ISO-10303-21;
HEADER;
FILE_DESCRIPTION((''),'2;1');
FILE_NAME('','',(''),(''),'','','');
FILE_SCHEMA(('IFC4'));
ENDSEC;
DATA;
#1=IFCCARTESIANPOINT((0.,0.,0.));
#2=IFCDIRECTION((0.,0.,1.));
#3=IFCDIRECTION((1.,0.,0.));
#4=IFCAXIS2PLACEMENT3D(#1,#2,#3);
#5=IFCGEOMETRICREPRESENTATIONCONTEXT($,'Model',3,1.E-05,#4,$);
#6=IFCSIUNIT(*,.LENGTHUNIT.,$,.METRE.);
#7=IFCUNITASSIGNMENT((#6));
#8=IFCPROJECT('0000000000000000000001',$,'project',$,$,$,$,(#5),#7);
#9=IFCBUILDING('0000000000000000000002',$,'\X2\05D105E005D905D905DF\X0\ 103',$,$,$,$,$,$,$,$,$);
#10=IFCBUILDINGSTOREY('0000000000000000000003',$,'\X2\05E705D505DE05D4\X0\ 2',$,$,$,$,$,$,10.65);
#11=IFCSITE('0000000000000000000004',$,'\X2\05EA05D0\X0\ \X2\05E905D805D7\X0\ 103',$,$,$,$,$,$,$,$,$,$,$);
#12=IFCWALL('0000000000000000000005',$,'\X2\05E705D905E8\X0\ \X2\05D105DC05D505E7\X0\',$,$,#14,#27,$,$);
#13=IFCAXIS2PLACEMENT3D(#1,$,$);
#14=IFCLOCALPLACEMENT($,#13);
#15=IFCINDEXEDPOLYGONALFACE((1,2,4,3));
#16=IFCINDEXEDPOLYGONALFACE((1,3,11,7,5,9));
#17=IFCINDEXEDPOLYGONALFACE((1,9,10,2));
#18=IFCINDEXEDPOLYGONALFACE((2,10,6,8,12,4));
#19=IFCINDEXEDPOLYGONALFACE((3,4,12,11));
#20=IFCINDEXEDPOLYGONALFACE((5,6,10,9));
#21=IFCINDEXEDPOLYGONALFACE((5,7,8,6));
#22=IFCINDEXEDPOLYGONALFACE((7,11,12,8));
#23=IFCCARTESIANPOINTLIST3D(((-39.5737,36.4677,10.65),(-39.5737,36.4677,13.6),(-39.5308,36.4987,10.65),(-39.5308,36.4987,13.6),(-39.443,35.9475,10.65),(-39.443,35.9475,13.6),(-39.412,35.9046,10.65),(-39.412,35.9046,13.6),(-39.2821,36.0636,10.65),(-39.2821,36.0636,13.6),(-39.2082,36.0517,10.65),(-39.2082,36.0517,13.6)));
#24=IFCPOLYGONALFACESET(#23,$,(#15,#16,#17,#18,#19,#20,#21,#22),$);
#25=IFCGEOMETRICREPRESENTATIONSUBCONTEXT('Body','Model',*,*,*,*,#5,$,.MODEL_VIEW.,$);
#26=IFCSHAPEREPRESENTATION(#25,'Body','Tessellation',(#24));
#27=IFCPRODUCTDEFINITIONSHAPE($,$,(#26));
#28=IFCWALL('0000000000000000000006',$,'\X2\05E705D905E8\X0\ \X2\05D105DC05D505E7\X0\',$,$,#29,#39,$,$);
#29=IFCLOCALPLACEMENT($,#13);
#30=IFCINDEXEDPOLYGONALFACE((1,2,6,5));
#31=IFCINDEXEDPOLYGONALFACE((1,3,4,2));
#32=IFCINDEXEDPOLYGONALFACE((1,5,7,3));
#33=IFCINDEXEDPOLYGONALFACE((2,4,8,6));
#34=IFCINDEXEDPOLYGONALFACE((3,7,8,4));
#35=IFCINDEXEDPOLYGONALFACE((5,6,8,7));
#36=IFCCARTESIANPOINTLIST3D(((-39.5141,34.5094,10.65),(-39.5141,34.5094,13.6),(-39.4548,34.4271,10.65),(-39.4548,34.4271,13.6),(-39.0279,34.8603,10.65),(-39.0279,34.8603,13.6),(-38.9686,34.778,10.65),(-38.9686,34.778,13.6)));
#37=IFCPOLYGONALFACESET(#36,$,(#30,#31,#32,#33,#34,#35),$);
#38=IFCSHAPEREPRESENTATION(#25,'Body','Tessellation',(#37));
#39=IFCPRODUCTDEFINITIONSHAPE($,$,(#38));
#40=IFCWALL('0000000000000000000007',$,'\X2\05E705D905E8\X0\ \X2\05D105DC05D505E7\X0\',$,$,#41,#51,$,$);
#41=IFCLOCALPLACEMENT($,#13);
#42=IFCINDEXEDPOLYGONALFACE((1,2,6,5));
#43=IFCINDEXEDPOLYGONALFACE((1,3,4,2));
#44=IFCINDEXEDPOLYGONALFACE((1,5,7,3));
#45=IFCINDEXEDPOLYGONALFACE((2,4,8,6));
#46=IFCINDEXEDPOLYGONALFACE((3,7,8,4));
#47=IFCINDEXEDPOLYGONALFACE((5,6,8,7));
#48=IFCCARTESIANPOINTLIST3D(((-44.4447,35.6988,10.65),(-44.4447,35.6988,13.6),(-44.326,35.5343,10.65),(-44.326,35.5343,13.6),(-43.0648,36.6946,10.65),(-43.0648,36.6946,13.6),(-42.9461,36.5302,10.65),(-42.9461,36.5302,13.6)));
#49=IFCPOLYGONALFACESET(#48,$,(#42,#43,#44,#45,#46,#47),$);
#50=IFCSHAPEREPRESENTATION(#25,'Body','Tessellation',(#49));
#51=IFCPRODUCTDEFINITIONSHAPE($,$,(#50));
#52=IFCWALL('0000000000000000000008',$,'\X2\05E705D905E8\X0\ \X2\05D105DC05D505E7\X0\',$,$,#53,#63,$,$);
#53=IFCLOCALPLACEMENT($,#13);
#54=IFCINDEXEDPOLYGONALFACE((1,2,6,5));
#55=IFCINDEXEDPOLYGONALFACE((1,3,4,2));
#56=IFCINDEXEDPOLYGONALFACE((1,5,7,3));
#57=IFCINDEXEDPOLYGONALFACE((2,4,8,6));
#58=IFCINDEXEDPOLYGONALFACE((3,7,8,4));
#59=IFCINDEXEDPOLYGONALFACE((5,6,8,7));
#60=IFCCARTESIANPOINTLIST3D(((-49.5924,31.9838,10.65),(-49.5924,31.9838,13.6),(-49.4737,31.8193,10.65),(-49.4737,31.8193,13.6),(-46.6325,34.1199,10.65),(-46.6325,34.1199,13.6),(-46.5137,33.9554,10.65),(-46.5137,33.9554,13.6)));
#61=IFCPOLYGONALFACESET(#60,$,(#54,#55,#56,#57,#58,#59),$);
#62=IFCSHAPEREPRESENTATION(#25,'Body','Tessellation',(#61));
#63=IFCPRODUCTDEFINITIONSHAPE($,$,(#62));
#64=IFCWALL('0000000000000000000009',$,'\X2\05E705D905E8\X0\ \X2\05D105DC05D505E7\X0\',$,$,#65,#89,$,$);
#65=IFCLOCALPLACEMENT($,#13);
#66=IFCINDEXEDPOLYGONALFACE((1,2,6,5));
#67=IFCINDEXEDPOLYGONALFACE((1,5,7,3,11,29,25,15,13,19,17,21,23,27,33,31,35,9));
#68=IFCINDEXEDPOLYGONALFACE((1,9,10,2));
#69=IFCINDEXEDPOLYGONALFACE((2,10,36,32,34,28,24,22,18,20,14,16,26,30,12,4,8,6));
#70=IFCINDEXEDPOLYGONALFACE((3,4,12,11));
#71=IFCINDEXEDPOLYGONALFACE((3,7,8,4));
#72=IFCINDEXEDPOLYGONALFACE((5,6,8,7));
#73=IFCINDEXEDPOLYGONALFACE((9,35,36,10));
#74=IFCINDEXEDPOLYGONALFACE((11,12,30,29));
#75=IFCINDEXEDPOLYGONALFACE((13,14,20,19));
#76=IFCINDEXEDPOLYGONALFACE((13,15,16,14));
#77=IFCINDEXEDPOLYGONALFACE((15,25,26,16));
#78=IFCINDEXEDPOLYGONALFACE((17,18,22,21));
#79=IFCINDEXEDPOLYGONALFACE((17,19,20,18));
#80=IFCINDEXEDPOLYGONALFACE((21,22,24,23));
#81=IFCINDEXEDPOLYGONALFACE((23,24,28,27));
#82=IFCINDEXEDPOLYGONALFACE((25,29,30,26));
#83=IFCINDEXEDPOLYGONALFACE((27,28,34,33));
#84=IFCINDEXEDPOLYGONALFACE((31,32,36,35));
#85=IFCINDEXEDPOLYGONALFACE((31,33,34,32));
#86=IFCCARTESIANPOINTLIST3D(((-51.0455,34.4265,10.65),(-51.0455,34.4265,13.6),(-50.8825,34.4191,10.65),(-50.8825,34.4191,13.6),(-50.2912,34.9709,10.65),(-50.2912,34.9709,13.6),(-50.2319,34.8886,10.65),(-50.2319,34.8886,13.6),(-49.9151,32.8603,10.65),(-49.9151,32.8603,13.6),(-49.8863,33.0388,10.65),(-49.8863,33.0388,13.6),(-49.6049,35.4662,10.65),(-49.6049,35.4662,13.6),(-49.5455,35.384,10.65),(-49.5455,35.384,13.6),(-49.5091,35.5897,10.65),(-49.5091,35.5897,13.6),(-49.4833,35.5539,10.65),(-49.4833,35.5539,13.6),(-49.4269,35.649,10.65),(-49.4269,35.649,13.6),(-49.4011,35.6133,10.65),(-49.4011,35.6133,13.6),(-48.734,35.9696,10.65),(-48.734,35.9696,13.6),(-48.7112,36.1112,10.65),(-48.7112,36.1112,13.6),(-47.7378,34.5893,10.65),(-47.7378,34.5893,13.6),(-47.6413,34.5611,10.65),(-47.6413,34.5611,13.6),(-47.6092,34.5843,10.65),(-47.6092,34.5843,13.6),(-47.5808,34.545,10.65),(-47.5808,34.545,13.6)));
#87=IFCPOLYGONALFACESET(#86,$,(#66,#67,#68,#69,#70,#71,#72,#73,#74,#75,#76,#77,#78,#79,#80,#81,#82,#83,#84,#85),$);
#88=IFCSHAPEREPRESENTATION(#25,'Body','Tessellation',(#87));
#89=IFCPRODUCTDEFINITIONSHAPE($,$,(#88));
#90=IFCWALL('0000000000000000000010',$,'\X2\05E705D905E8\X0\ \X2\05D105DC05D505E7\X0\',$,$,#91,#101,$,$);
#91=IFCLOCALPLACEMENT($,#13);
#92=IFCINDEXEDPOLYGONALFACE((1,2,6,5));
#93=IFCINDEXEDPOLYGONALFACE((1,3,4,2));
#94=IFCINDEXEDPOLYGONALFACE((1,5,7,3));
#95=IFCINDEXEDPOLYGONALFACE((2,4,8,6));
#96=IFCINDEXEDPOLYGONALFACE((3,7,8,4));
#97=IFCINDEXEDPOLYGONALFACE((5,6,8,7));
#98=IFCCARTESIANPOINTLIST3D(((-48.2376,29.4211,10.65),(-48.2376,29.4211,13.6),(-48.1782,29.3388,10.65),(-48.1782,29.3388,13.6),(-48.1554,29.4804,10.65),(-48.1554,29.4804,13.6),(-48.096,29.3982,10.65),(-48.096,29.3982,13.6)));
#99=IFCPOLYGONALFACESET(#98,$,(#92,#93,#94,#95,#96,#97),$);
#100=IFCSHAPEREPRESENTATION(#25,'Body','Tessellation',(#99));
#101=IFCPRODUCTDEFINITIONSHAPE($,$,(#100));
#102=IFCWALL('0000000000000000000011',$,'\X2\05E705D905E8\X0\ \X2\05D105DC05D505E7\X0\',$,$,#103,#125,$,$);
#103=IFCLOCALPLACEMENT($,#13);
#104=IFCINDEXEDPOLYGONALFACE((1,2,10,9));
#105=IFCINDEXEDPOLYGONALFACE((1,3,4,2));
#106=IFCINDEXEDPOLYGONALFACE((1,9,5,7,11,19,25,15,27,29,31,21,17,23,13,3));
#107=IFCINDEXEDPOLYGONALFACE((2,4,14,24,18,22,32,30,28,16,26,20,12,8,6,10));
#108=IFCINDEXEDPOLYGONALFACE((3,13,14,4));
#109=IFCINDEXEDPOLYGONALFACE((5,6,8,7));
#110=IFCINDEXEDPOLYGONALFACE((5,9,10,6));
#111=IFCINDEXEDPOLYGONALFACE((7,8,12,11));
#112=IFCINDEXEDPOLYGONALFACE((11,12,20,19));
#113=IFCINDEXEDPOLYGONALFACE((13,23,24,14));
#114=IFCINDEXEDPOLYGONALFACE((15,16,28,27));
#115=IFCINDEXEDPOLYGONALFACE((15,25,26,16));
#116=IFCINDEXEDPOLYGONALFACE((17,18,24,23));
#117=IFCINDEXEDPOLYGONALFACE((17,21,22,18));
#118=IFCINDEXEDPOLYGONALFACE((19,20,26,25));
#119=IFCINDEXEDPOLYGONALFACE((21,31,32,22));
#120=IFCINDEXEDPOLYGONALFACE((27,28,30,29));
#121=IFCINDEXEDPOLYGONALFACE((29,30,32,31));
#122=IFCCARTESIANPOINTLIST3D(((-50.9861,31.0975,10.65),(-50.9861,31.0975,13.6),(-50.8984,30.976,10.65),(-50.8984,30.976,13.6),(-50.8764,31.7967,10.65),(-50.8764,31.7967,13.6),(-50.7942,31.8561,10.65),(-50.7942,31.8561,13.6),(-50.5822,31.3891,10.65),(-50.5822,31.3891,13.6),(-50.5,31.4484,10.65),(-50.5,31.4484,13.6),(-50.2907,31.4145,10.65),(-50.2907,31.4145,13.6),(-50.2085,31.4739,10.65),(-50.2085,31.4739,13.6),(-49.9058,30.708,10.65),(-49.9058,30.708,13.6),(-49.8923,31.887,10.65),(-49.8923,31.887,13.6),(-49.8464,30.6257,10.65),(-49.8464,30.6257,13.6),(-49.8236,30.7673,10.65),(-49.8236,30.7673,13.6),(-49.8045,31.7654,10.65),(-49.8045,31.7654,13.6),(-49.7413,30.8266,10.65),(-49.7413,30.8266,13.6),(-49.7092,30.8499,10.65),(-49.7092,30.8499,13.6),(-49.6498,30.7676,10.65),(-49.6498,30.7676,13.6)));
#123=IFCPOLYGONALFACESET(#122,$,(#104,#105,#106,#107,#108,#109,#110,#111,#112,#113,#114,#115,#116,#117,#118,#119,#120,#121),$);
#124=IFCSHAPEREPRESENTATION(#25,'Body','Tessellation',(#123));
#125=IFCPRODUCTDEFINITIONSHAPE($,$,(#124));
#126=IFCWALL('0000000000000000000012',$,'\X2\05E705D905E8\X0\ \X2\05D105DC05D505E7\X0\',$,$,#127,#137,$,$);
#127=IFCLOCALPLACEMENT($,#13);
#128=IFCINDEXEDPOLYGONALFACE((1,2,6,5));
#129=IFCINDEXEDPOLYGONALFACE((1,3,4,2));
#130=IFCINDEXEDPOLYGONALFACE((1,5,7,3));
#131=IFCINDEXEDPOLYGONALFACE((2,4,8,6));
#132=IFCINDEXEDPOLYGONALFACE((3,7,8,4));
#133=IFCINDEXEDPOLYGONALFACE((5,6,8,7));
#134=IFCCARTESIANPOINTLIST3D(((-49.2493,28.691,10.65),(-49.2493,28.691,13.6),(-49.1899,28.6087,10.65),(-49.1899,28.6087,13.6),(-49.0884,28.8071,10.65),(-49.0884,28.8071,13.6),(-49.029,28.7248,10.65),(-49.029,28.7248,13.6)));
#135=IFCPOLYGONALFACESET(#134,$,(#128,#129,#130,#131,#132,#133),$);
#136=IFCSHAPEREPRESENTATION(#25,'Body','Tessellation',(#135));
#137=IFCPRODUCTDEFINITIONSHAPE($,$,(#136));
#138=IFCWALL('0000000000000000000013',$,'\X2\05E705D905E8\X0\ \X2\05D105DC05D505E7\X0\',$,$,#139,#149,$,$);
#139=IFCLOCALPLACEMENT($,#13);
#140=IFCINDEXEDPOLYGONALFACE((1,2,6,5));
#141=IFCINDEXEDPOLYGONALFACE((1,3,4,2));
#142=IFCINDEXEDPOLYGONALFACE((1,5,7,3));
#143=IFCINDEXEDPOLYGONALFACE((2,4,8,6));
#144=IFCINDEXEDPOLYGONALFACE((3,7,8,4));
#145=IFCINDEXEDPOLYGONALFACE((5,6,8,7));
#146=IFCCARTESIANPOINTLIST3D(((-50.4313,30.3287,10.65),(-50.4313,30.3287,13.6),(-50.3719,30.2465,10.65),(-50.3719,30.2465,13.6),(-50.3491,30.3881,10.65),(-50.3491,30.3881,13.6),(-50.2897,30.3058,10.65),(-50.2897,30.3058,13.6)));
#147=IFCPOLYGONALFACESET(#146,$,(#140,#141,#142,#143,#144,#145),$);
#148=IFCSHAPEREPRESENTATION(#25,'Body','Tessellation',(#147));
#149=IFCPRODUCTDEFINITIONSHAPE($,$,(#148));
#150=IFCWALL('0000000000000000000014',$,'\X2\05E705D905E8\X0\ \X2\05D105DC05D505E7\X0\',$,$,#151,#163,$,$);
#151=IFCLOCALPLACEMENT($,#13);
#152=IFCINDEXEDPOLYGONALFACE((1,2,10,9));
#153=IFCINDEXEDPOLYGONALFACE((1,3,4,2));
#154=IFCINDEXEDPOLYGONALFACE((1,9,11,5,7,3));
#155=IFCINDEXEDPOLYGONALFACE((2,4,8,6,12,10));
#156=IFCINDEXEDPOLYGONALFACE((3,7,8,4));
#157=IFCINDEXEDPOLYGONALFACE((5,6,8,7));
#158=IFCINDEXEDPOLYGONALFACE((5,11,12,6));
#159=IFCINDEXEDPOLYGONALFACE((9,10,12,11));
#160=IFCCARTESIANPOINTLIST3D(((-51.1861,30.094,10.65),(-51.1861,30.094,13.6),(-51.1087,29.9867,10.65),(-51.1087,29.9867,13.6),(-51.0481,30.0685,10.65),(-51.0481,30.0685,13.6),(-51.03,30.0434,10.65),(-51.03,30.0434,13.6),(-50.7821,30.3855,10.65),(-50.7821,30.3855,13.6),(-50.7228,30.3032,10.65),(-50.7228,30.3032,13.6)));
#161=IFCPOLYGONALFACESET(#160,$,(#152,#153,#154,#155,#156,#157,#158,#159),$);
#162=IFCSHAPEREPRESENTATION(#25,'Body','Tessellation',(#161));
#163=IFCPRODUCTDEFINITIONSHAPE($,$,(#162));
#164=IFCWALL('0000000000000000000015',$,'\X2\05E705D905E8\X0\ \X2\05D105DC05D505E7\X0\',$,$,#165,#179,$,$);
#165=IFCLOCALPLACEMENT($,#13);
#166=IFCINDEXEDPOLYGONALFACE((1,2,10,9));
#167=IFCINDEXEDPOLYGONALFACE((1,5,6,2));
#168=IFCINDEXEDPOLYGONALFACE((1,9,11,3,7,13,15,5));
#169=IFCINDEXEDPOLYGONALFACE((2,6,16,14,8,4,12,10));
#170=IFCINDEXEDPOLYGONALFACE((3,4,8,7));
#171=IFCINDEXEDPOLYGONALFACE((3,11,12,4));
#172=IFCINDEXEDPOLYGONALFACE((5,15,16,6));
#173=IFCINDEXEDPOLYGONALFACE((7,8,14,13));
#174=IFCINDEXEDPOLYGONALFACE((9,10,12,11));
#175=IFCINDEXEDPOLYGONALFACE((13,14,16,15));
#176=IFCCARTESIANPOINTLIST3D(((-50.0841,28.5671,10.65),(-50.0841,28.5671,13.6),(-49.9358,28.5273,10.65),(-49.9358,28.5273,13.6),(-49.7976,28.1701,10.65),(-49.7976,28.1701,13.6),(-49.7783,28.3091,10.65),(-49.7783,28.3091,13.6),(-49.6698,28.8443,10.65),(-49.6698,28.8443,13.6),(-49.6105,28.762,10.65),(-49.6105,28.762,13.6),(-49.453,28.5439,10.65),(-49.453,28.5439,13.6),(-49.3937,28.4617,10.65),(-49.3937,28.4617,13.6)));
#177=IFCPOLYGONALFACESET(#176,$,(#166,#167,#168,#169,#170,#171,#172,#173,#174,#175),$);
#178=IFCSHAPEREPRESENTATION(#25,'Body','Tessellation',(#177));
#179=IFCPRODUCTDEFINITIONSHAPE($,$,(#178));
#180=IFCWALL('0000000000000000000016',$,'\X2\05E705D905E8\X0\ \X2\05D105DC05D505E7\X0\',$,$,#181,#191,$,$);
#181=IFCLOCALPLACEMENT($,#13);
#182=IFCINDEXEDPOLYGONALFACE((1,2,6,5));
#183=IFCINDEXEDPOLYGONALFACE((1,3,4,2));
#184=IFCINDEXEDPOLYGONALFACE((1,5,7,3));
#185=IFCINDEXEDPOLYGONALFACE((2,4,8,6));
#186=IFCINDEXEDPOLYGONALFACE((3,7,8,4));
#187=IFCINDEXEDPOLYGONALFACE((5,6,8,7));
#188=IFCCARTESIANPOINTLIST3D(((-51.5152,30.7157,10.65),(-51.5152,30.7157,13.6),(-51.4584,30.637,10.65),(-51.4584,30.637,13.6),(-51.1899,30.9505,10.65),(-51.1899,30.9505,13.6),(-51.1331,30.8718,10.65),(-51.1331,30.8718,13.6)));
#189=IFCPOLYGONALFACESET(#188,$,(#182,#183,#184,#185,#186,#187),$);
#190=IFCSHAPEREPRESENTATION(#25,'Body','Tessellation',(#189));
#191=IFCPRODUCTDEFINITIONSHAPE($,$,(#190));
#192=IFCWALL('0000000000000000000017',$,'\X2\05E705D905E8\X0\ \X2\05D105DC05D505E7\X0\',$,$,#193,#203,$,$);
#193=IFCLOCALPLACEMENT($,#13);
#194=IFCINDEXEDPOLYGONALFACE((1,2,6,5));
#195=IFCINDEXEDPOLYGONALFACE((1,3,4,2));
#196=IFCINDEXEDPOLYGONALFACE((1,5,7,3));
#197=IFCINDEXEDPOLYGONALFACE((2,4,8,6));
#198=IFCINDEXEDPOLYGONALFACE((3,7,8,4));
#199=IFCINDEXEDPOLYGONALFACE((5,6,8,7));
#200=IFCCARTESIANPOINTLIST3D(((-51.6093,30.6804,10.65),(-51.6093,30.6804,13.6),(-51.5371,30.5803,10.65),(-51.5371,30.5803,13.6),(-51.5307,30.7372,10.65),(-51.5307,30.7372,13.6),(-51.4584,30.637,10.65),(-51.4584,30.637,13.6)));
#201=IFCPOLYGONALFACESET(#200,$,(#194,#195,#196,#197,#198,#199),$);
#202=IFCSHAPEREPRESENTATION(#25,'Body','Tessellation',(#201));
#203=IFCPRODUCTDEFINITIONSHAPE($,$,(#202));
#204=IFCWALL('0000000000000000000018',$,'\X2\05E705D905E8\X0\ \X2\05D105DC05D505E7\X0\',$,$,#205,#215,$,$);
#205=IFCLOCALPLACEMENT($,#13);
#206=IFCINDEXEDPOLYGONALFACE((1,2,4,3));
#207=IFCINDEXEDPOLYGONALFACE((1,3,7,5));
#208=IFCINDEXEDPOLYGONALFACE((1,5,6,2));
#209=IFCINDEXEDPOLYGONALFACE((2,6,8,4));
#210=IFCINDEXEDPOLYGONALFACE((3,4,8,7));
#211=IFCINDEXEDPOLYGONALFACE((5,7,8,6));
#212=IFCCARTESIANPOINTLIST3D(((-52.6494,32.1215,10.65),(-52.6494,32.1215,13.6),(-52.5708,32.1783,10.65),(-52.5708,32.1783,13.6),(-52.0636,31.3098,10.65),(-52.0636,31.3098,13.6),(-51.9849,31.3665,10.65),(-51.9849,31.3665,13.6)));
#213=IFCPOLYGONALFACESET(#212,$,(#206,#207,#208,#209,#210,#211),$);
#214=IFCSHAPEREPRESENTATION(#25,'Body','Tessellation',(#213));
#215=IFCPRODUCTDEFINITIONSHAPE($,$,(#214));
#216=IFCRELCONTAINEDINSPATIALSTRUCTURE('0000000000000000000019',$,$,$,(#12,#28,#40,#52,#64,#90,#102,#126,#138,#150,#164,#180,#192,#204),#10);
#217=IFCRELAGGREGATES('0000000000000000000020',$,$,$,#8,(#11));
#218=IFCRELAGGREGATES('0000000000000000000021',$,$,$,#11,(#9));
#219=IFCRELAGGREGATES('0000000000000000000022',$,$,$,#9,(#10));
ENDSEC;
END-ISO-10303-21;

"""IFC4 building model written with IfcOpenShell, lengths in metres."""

from ifc_helpers import new_model, si_unit, frame, origin_with_axes, context, subcontext, project, spatial, polyline, outline, extrude, element, save


model = new_model("IFC4")

# Units and contexts
model_context = context("Model", 3, precision=1e-05, world=origin_with_axes())
body_context = subcontext(model_context, "Body", "Model", "MODEL_VIEW")
ifc_project = project(units=[si_unit("LENGTHUNIT", "METRE")], contexts=[model_context])

# Site, building, storey
site = spatial("IfcSite", under=ifc_project, Name="תא שטח 103")
building = spatial("IfcBuilding", under=site, Name="בניין 103")
storey = spatial("IfcBuildingStorey", under=building, Name="קומה 2", Elevation=10.65)

# Walls
element("IfcWall", 1, inside=storey, Name="קיר בלוק", context=body_context, shape_type="SweptSolid", body=[
    extrude(outline(polyline([(-39.2821, 36.0636), (-39.5737, 36.4677), (-39.5308, 36.4987), (-39.2082, 36.0517), (-39.412, 35.9046), (-39.443, 35.9475), (-39.2821, 36.0636)])), frame((0.0, 0.0, 10.65)), (0.0, 0.0, 1.0), 2.95),
])
element("IfcWall", 2, inside=storey, Name="קיר בלוק", context=body_context, shape_type="SweptSolid", body=[
    extrude(outline(polyline([(-38.9686, 34.778), (-39.4548, 34.4271), (-39.5141, 34.5094), (-39.0279, 34.8603), (-38.9686, 34.778)])), frame((0.0, 0.0, 10.65)), (0.0, 0.0, 1.0), 2.95),
])
element("IfcWall", 3, inside=storey, Name="קיר בלוק", context=body_context, shape_type="SweptSolid", body=[
    extrude(outline(polyline([(-44.326, 35.5343), (-44.4447, 35.6988), (-43.0648, 36.6946), (-42.9461, 36.5302), (-44.326, 35.5343)])), frame((0.0, 0.0, 10.65)), (0.0, 0.0, 1.0), 2.95),
])
element("IfcWall", 4, inside=storey, Name="קיר בלוק", context=body_context, shape_type="SweptSolid", body=[
    extrude(outline(polyline([(-49.4737, 31.8193), (-49.5924, 31.9838), (-46.6325, 34.1199), (-46.5137, 33.9554), (-49.4737, 31.8193)])), frame((0.0, 0.0, 10.65)), (0.0, 0.0, 1.0), 2.95),
])
element("IfcWall", 5, inside=storey, Name="קיר בלוק", context=body_context, shape_type="SweptSolid", body=[
    extrude(outline(polyline([(-49.9151, 32.8603), (-51.0455, 34.4265), (-50.2912, 34.9709), (-50.2319, 34.8886), (-50.8825, 34.4191), (-49.8863, 33.0388), (-47.7378, 34.5893), (-48.734, 35.9696), (-49.5455, 35.384), (-49.6049, 35.4662), (-49.4833, 35.5539), (-49.5091, 35.5897), (-49.4269, 35.649), (-49.4011, 35.6133), (-48.7112, 36.1112), (-47.6092, 34.5843), (-47.6413, 34.5611), (-47.5808, 34.545), (-49.9151, 32.8603)])), frame((0.0, 0.0, 10.65)), (0.0, 0.0, 1.0), 2.95),
])
element("IfcWall", 6, inside=storey, Name="קיר בלוק", context=body_context, shape_type="SweptSolid", body=[
    extrude(outline(polyline([(-48.096, 29.3982), (-48.1782, 29.3388), (-48.2376, 29.4211), (-48.1554, 29.4804), (-48.096, 29.3982)])), frame((0.0, 0.0, 10.65)), (0.0, 0.0, 1.0), 2.95),
])
element("IfcWall", 7, inside=storey, Name="קיר בלוק", context=body_context, shape_type="SweptSolid", body=[
    extrude(outline(polyline([(-49.9058, 30.708), (-49.8236, 30.7673), (-50.2907, 31.4145), (-50.8984, 30.976), (-50.9861, 31.0975), (-50.5822, 31.3891), (-50.8764, 31.7967), (-50.7942, 31.8561), (-50.5, 31.4484), (-49.8923, 31.887), (-49.8045, 31.7654), (-50.2085, 31.4739), (-49.7413, 30.8266), (-49.7092, 30.8499), (-49.6498, 30.7676), (-49.8464, 30.6257), (-49.9058, 30.708)])), frame((0.0, 0.0, 10.65)), (0.0, 0.0, 1.0), 2.95),
])
element("IfcWall", 8, inside=storey, Name="קיר בלוק", context=body_context, shape_type="SweptSolid", body=[
    extrude(outline(polyline([(-49.0884, 28.8071), (-49.029, 28.7248), (-49.1899, 28.6087), (-49.2493, 28.691), (-49.0884, 28.8071)])), frame((0.0, 0.0, 10.65)), (0.0, 0.0, 1.0), 2.95),
])
element("IfcWall", 9, inside=storey, Name="קיר בלוק", context=body_context, shape_type="SweptSolid", body=[
    extrude(outline(polyline([(-50.2897, 30.3058), (-50.3719, 30.2465), (-50.4313, 30.3287), (-50.3491, 30.3881), (-50.2897, 30.3058)])), frame((0.0, 0.0, 10.65)), (0.0, 0.0, 1.0), 2.95),
])
element("IfcWall", 10, inside=storey, Name="קיר בלוק", context=body_context, shape_type="SweptSolid", body=[
    extrude(outline(polyline([(-51.1087, 29.9867), (-51.1861, 30.094), (-50.7821, 30.3855), (-50.7228, 30.3032), (-51.0481, 30.0685), (-51.03, 30.0434), (-51.1087, 29.9867)])), frame((0.0, 0.0, 10.65)), (0.0, 0.0, 1.0), 2.95),
])
element("IfcWall", 11, inside=storey, Name="קיר בלוק", context=body_context, shape_type="SweptSolid", body=[
    extrude(outline(polyline([(-49.3937, 28.4617), (-49.7976, 28.1701), (-50.0841, 28.5671), (-49.6698, 28.8443), (-49.6105, 28.762), (-49.9358, 28.5273), (-49.7783, 28.3091), (-49.453, 28.5439), (-49.3937, 28.4617)])), frame((0.0, 0.0, 10.65)), (0.0, 0.0, 1.0), 2.95),
])
element("IfcWall", 12, inside=storey, Name="קיר בלוק", context=body_context, shape_type="SweptSolid", body=[
    extrude(outline(polyline([(-51.1331, 30.8718), (-51.4584, 30.637), (-51.5152, 30.7157), (-51.1899, 30.9505), (-51.1331, 30.8718)])), frame((0.0, 0.0, 10.65)), (0.0, 0.0, 1.0), 2.95),
])
element("IfcWall", 13, inside=storey, Name="קיר בלוק", context=body_context, shape_type="SweptSolid", body=[
    extrude(outline(polyline([(-51.6093, 30.6804), (-51.5307, 30.7372), (-51.4584, 30.637), (-51.5371, 30.5803), (-51.6093, 30.6804)])), frame((0.0, 0.0, 10.65)), (0.0, 0.0, 1.0), 2.95),
])
element("IfcWall", 14, inside=storey, Name="קיר בלוק", context=body_context, shape_type="SweptSolid", body=[
    extrude(outline(polyline([(-52.0636, 31.3098), (-52.6494, 32.1215), (-52.5708, 32.1783), (-51.9849, 31.3665), (-52.0636, 31.3098)])), frame((0.0, 0.0, 10.65)), (0.0, 0.0, 1.0), 2.95),
])

save(model, "model.ifc")
